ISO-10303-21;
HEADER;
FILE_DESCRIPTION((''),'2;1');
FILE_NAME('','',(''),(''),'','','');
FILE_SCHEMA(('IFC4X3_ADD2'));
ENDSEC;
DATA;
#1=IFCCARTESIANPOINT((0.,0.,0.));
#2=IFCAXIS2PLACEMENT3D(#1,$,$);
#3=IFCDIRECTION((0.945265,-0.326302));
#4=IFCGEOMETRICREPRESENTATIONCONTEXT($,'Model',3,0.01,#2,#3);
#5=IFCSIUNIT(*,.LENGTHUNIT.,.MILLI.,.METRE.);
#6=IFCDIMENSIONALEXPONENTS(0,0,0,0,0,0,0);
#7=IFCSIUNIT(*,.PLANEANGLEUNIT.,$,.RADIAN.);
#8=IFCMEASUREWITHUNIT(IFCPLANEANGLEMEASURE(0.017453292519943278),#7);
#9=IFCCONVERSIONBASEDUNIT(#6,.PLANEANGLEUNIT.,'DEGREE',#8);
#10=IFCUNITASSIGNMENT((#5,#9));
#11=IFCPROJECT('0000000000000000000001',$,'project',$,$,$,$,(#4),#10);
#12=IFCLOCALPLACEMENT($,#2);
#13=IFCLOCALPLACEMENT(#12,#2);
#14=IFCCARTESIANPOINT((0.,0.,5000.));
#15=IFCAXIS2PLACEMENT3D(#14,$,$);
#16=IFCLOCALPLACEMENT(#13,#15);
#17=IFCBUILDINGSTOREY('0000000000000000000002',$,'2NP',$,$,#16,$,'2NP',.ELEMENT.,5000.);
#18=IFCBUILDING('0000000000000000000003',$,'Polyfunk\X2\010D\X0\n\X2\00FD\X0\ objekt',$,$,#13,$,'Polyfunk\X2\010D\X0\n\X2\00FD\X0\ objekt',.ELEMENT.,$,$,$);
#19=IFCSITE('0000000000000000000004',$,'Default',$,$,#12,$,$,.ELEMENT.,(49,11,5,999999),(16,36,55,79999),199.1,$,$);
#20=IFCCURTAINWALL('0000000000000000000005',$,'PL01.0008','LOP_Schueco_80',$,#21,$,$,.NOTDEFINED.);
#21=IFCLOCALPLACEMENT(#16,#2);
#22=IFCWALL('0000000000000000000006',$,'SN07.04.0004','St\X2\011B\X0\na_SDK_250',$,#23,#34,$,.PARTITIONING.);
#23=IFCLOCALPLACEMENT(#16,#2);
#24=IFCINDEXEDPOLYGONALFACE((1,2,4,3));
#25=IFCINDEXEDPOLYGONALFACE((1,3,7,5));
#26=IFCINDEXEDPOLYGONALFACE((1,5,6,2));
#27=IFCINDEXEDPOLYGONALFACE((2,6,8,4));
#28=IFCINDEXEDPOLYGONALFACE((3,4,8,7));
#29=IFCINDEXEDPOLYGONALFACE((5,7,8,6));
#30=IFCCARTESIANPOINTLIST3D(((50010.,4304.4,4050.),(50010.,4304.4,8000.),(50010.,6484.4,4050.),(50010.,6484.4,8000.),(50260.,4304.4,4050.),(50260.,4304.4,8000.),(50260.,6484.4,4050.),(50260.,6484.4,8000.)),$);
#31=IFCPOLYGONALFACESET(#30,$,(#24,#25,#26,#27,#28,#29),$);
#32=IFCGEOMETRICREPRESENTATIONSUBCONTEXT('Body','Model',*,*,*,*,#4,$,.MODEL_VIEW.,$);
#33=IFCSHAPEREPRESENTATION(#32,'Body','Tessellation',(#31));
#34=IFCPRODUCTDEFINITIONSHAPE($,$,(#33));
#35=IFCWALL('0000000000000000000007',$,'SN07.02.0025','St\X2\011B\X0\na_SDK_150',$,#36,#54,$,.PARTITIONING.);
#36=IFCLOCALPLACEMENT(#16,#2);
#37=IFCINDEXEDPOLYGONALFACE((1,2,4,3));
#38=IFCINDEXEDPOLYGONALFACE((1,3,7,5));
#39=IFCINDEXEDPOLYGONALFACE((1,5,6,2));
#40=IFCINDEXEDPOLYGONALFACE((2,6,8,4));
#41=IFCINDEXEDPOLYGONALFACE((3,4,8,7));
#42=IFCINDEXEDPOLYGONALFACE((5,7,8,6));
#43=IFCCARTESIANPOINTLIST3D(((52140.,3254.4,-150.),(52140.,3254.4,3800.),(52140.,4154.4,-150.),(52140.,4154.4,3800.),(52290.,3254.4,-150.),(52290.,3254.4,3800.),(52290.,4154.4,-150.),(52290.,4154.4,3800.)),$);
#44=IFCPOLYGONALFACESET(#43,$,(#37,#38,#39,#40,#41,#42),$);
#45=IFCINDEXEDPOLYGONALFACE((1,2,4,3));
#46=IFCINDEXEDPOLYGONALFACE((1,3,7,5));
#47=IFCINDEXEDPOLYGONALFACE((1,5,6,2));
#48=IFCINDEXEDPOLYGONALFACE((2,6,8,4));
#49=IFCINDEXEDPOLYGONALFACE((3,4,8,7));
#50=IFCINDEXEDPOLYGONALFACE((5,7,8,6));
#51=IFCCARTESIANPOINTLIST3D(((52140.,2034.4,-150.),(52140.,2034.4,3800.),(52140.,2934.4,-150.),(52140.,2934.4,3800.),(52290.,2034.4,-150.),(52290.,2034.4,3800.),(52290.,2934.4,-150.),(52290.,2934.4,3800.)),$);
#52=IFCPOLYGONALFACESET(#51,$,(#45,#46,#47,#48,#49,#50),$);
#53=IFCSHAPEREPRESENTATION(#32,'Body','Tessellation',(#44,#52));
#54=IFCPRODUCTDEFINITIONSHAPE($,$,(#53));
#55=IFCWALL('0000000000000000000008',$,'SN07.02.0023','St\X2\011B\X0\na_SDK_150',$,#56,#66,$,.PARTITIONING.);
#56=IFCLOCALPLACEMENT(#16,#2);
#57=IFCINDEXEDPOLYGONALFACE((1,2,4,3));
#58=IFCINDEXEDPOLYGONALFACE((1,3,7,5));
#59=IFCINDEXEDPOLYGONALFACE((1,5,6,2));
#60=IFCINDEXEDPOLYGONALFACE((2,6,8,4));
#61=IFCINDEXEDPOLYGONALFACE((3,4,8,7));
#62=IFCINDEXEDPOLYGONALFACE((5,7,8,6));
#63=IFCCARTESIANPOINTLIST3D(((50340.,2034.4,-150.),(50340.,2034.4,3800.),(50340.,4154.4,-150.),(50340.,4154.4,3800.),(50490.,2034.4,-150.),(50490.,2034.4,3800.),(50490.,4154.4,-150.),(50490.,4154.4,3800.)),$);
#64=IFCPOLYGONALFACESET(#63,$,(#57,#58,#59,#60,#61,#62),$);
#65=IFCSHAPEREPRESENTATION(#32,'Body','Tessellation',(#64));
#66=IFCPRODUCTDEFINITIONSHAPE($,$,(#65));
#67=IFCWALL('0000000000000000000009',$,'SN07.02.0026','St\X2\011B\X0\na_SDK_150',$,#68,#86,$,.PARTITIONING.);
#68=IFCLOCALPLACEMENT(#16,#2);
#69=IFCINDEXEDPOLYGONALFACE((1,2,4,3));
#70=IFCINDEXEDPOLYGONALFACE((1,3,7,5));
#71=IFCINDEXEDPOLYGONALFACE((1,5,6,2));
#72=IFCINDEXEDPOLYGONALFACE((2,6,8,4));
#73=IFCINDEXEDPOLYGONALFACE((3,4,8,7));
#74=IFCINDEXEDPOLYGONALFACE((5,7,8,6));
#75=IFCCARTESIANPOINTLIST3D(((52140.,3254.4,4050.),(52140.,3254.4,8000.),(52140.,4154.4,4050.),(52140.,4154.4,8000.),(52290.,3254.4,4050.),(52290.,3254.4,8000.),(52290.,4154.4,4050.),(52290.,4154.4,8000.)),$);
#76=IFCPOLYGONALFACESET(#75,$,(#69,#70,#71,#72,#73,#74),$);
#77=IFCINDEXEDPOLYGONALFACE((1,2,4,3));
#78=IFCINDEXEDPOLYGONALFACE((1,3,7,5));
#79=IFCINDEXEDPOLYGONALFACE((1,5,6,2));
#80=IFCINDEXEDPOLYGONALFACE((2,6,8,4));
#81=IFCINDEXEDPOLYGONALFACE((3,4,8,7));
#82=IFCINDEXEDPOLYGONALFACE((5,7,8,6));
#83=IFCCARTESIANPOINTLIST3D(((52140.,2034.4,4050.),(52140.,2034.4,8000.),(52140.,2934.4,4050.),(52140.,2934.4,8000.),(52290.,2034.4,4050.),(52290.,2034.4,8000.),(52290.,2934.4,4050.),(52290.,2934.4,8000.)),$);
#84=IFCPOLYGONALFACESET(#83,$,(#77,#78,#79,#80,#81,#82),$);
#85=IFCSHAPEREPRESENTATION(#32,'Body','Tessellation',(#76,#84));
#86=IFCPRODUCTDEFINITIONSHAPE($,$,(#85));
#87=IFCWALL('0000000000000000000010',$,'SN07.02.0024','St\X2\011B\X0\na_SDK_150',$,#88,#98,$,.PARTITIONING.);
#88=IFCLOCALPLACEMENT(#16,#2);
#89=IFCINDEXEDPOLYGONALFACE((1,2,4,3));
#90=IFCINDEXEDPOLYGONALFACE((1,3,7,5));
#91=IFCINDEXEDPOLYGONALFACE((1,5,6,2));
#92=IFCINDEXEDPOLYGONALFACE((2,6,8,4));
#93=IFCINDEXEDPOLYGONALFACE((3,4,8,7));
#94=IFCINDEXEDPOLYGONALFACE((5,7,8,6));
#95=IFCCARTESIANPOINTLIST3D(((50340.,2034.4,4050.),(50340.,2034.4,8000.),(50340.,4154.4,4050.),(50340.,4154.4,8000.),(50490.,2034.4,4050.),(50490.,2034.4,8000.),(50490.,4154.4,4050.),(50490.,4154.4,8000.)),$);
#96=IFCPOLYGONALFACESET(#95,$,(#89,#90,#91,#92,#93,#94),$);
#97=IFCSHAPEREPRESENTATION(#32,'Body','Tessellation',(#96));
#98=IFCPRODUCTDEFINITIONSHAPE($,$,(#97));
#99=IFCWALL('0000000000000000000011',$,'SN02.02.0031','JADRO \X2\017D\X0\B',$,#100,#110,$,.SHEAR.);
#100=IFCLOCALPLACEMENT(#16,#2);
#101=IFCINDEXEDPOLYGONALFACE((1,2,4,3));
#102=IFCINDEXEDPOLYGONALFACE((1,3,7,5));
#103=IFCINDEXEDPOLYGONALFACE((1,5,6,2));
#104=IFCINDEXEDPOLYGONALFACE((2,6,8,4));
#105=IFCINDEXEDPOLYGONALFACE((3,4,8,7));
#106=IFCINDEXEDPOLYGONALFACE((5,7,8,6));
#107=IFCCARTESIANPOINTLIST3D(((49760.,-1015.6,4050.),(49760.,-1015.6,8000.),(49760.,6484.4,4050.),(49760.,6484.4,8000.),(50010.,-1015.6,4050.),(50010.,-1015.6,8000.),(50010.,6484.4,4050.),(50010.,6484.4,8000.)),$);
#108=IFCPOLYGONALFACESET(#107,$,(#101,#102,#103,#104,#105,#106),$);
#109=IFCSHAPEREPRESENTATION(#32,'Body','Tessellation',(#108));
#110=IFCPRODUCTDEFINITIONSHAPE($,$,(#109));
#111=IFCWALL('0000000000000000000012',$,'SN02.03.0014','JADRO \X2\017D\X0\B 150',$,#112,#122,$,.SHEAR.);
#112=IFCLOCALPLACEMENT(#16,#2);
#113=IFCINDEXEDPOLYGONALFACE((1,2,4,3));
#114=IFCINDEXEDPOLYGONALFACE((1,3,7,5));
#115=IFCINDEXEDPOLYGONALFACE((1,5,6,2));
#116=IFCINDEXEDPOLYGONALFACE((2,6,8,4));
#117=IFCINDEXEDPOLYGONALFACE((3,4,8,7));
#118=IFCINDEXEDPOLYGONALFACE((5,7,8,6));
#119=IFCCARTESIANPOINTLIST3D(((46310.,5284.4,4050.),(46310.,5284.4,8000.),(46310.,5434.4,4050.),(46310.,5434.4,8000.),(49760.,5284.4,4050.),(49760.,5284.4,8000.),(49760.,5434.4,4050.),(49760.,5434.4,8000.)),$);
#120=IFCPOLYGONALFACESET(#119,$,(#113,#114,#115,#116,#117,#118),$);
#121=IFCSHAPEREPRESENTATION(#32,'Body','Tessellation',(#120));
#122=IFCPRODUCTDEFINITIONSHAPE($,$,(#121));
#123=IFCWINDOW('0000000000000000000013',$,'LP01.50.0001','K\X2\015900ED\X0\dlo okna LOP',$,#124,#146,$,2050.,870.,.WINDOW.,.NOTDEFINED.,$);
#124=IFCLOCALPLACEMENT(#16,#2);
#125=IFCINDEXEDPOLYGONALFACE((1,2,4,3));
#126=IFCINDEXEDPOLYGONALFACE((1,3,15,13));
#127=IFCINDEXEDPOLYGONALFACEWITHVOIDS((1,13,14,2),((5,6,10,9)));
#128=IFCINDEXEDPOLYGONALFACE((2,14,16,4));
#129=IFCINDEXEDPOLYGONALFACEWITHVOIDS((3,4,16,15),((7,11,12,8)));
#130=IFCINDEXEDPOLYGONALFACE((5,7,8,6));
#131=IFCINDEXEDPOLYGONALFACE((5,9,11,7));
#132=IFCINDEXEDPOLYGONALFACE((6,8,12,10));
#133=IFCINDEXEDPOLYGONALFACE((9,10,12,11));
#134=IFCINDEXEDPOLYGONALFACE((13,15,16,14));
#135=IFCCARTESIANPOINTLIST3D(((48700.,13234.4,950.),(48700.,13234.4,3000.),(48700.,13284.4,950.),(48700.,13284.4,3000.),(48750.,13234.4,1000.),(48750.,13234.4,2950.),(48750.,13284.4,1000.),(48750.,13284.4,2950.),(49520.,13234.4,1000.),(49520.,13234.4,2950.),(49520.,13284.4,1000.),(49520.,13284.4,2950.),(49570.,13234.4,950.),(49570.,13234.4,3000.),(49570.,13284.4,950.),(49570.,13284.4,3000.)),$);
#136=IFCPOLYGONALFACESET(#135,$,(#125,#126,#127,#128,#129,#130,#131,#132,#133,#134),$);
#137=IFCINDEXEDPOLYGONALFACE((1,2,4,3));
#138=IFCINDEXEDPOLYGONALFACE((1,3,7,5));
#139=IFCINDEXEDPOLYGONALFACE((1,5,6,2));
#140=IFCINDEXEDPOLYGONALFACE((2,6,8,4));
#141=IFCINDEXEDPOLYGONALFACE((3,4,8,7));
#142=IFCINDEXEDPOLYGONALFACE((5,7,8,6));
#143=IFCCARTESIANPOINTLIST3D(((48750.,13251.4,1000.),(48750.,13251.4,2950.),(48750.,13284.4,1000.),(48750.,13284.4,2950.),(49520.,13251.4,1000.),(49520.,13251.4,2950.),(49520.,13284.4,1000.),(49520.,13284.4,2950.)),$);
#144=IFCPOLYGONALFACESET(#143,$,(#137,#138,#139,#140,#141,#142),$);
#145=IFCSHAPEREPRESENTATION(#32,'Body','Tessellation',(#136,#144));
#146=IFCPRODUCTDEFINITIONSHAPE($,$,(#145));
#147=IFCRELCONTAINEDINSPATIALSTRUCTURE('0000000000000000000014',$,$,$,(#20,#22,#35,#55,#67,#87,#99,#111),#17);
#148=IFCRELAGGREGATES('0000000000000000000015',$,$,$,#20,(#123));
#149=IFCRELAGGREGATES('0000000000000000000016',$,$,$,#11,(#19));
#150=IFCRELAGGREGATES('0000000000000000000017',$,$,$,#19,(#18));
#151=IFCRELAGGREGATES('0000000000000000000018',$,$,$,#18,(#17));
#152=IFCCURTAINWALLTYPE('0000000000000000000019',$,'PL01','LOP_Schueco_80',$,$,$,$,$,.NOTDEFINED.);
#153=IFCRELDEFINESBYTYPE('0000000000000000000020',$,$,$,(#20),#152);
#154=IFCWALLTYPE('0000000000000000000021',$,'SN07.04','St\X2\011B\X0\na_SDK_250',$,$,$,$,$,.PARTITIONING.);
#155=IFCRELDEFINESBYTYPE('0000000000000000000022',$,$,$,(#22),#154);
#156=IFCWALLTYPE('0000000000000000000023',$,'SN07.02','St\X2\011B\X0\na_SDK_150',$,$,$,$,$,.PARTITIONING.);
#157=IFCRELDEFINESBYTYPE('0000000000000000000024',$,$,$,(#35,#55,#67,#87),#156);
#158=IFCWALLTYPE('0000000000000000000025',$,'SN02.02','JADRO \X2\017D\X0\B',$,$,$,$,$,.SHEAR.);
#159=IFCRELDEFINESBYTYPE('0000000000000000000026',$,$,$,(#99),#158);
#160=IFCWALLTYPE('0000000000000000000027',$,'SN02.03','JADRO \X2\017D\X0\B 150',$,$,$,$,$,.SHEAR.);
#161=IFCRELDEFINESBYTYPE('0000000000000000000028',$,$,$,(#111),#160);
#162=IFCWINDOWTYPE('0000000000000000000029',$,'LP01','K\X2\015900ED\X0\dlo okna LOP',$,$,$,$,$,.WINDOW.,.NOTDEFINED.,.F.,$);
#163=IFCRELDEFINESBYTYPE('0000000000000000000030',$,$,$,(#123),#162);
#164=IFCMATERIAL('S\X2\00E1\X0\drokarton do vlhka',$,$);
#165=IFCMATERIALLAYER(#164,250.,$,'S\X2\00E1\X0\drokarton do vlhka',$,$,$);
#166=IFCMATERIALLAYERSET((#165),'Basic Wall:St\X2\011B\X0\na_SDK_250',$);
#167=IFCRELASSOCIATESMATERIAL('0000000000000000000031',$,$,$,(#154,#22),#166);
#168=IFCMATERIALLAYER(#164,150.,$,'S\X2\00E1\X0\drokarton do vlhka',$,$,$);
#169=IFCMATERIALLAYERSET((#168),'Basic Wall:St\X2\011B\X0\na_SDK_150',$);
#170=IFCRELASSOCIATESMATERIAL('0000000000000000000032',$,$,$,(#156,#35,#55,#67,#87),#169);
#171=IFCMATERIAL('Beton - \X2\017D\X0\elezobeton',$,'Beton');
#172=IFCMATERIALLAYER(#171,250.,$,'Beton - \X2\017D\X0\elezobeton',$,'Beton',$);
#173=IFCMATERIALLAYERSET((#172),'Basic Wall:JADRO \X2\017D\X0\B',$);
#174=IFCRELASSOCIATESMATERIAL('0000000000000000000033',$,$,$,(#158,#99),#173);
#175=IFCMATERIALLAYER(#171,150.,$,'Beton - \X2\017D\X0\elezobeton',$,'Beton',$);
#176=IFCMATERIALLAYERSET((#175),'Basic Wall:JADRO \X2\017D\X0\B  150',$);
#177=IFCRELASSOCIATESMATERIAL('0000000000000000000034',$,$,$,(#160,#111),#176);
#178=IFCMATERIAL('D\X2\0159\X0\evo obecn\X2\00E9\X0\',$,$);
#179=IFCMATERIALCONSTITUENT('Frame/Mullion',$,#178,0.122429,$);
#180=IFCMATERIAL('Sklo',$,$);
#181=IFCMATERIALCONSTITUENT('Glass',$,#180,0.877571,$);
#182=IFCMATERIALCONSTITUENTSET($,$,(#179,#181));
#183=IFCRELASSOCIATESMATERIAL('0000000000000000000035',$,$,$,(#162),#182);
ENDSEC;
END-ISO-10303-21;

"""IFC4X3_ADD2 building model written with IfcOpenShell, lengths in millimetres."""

from ifc_helpers import new_model, entity, si_unit, converted_unit, direction, frame, frame_2d, origin, origin_2d_with_axis, place, context, subcontext, project, spatial, polyline, rectangle, outline, extrude, clip, bounded_halfspace, source, transform, mapped, material, layer, layer_set, constituent, constituent_set, type_object, type_shapes, element, aggregate, save


model = new_model("IFC4X3_ADD2")

# Units and contexts
model_context = context("Model", 3, precision=0.01, world=origin(), true_north=direction((0.945265, -0.326302)))
body_context = subcontext(model_context, "Body", "Model", "MODEL_VIEW")
ifc_project = project(units=[si_unit("LENGTHUNIT", "METRE", prefix="MILLI"), converted_unit("PLANEANGLEUNIT", "DEGREE", entity("IfcPlaneAngleMeasure", 0.017453292519943278), si_unit("PLANEANGLEUNIT", "RADIAN"), dimensions=[0, 0, 0, 0, 0, 0, 0])], contexts=[model_context])

# Site, building, storey
site_placement = place(None, origin())
site = spatial("IfcSite", under=ifc_project, at=site_placement, Name="Default", CompositionType="ELEMENT", RefLatitude=(49, 11, 5, 999999), RefLongitude=(16, 36, 55, 79999), RefElevation=199.1)
building_placement = place(site_placement, origin())
building = spatial("IfcBuilding", under=site, at=building_placement, Name="Polyfunkčný objekt", LongName="Polyfunkčný objekt", CompositionType="ELEMENT")
storey_placement = place(building_placement, frame((0.0, 0.0, 5000.0)))
storey = spatial("IfcBuildingStorey", under=building, at=storey_placement, Name="2NP", LongName="2NP", CompositionType="ELEMENT", Elevation=5000.0)

# Curtain wall
curtain_wall_type = type_object("IfcCurtainWallType", Name="PL01", Description="LOP_Schueco_80", PredefinedType="NOTDEFINED")
curtain_wall_placement = place(storey_placement, frame((0.0, 0.0, -5000.0)))
curtain_wall = element("IfcCurtainWall", 1, at=curtain_wall_placement, inside=storey, type_object=curtain_wall_type, Name="PL01.0008", Description="LOP_Schueco_80", PredefinedType="NOTDEFINED")
ifc_material_1 = material(Name="Sklo")

# Walls
ifc_material_2 = material(Name="Sádrokarton do vlhka")
ifc_layer_1 = layer(ifc_material_2, 250.0, Name="Sádrokarton do vlhka")
ifc_layer_set_1 = layer_set([ifc_layer_1], Name="Basic Wall:Stěna_SDK_250")
wall_type_1 = type_object("IfcWallType", Name="SN07.04", Description="Stěna_SDK_250", PredefinedType="PARTITIONING", material=ifc_layer_set_1)
wall_1_placement = place(storey_placement, frame((50135.0, 6484.4, 4050.0), z_axis=(0.0, 0.0, 1.0), x_axis=(0.0, -1.0, 0.0)))
element("IfcWall", 2, at=wall_1_placement, inside=storey, type_object=wall_type_1, material=ifc_layer_set_1, Name="SN07.04.0004", Description="Stěna_SDK_250", PredefinedType="PARTITIONING", context=body_context, shape_type="Clipping", body=[
    clip(clip(extrude(rectangle(XDim=2180.0, YDim=250.0, at=frame_2d((1090.0, 0.0), x_axis=(-1.0, 0.0))), origin(), (0.0, 0.0, 1.0), 3950.0), bounded_halfspace(frame((2180.0, -125.0, 0.0), z_axis=(0.0, 0.0, 1.0), x_axis=(0.0, -1.0, 0.0)), True, frame((2180.0, -125.0, 0.0)), polyline([(0.0, 0.0), (0.0, 250.0), (-1930.0, 250.0), (-2180.0, 250.0), (-2180.0, 0.0), (0.0, 0.0)]))), bounded_halfspace(frame((0.0, -125.0, 3950.0), z_axis=(0.0, 0.0, -1.0), x_axis=(0.0, 1.0, 0.0)), True, frame((0.0, -125.0, 3950.0)), polyline([(0.0, 0.0), (2180.0, 0.0), (2180.0, 250.0), (250.0, 250.0), (0.0, 250.0), (0.0, 0.0)]))),
])
ifc_layer_2 = layer(ifc_material_2, 150.0, Name="Sádrokarton do vlhka")
ifc_layer_set_2 = layer_set([ifc_layer_2], Name="Basic Wall:Stěna_SDK_150")
wall_type_2 = type_object("IfcWallType", Name="SN07.02", Description="Stěna_SDK_150", PredefinedType="PARTITIONING", material=ifc_layer_set_2)
wall_2_placement = place(storey_placement, frame((52215.0, 4154.4, -150.0), z_axis=(0.0, 0.0, 1.0), x_axis=(0.0, -1.0, 0.0)))
element("IfcWall", 3, at=wall_2_placement, inside=storey, type_object=wall_type_2, material=ifc_layer_set_2, Name="SN07.02.0025", Description="Stěna_SDK_150", PredefinedType="PARTITIONING", context=body_context, shape_type="SweptSolid", body=[
    extrude(rectangle(XDim=900.0, YDim=150.0, at=frame_2d((0.0, 0.0), x_axis=(1.0, 0.0))), frame((450.0, 0.0, 0.0)), (0.0, 0.0, 1.0), 3950.0),
    extrude(rectangle(XDim=900.0, YDim=150.0, at=frame_2d((0.0, 0.0), x_axis=(1.0, 0.0))), frame((1670.0, 0.0, 0.0), z_axis=(0.0, 0.0, 1.0), x_axis=(-1.0, 0.0, 0.0)), (0.0, 0.0, 1.0), 3950.0),
])
wall_3_placement = place(storey_placement, frame((50415.0, 4154.4, -150.0), z_axis=(0.0, 0.0, 1.0), x_axis=(0.0, -1.0, 0.0)))
element("IfcWall", 4, at=wall_3_placement, inside=storey, type_object=wall_type_2, material=ifc_layer_set_2, Name="SN07.02.0023", Description="Stěna_SDK_150", PredefinedType="PARTITIONING", context=body_context, shape_type="Clipping", body=[
    clip(clip(extrude(rectangle(XDim=2120.0, YDim=150.0, at=frame_2d((1060.0, 0.0), x_axis=(-1.0, 0.0))), origin(), (0.0, 0.0, 1.0), 3950.0), bounded_halfspace(frame((2120.0, -75.0, 0.0), z_axis=(0.0, 0.0, 1.0), x_axis=(0.0, -1.0, 0.0)), True, frame((2120.0, -75.0, 0.0)), polyline([(0.0, 0.0), (0.0, 150.0), (-900.0, 150.0), (-1220.0, 150.0), (-2120.0, 150.0), (-2120.0, 0.0), (0.0, 0.0)]))), bounded_halfspace(frame((0.0, -75.0, 3950.0), z_axis=(0.0, 0.0, -1.0), x_axis=(0.0, 1.0, 0.0)), True, frame((0.0, -75.0, 3950.0)), polyline([(0.0, 0.0), (2120.0, 0.0), (2120.0, 150.0), (1220.0, 150.0), (900.0, 150.0), (0.0, 150.0), (0.0, 0.0)]))),
])
wall_4_placement = place(storey_placement, frame((52215.0, 4154.4, 4050.0), z_axis=(0.0, 0.0, 1.0), x_axis=(0.0, -1.0, 0.0)))
element("IfcWall", 5, at=wall_4_placement, inside=storey, type_object=wall_type_2, material=ifc_layer_set_2, Name="SN07.02.0026", Description="Stěna_SDK_150", PredefinedType="PARTITIONING", context=body_context, shape_type="SweptSolid", body=[
    extrude(rectangle(XDim=900.0, YDim=150.0, at=frame_2d((0.0, 0.0), x_axis=(1.0, 0.0))), frame((450.0, 0.0, 0.0)), (0.0, 0.0, 1.0), 3950.0),
    extrude(rectangle(XDim=900.0, YDim=150.0, at=frame_2d((0.0, 0.0), x_axis=(1.0, 0.0))), frame((1670.0, 0.0, 0.0), z_axis=(0.0, 0.0, 1.0), x_axis=(-1.0, 0.0, 0.0)), (0.0, 0.0, 1.0), 3950.0),
])
wall_5_placement = place(storey_placement, frame((50415.0, 4154.4, 4050.0), z_axis=(0.0, 0.0, 1.0), x_axis=(0.0, -1.0, 0.0)))
element("IfcWall", 6, at=wall_5_placement, inside=storey, type_object=wall_type_2, material=ifc_layer_set_2, Name="SN07.02.0024", Description="Stěna_SDK_150", PredefinedType="PARTITIONING", context=body_context, shape_type="Clipping", body=[
    clip(clip(extrude(rectangle(XDim=2120.0, YDim=150.0, at=frame_2d((1060.0, 0.0), x_axis=(-1.0, 0.0))), origin(), (0.0, 0.0, 1.0), 3950.0), bounded_halfspace(frame((2120.0, -75.0, 0.0), z_axis=(0.0, 0.0, 1.0), x_axis=(0.0, -1.0, 0.0)), True, frame((2120.0, -75.0, 0.0)), polyline([(0.0, 0.0), (0.0, 150.0), (-900.0, 150.0), (-1220.0, 150.0), (-2120.0, 150.0), (-2120.0, 0.0), (0.0, 0.0)]))), bounded_halfspace(frame((0.0, -75.0, 3950.0), z_axis=(0.0, 0.0, -1.0), x_axis=(0.0, 1.0, 0.0)), True, frame((0.0, -75.0, 3950.0)), polyline([(0.0, 0.0), (2120.0, 0.0), (2120.0, 150.0), (1220.0, 150.0), (900.0, 150.0), (0.0, 150.0), (0.0, 0.0)]))),
])
ifc_material_3 = material(Name="Beton - Železobeton", Category="Beton")
ifc_layer_3 = layer(ifc_material_3, 250.0, Name="Beton - Železobeton", Category="Beton")
ifc_layer_set_3 = layer_set([ifc_layer_3], Name="Basic Wall:JADRO ŽB")
wall_type_3 = type_object("IfcWallType", Name="SN02.02", Description="JADRO ŽB", PredefinedType="SHEAR", material=ifc_layer_set_3)
wall_6_placement = place(storey_placement, frame((49885.0, 6484.4, 4050.0), z_axis=(0.0, 0.0, 1.0), x_axis=(0.0, -1.0, 0.0)))
element("IfcWall", 7, at=wall_6_placement, inside=storey, type_object=wall_type_3, material=ifc_layer_set_3, Name="SN02.02.0031", Description="JADRO ŽB", PredefinedType="SHEAR", context=body_context, shape_type="Clipping", body=[
    clip(clip(extrude(rectangle(XDim=7500.0, YDim=250.0, at=frame_2d((3750.0, 0.0), x_axis=(-1.0, 0.0))), origin(), (0.0, 0.0, 1.0), 3950.0), bounded_halfspace(frame((7500.0, -125.0, 0.0), z_axis=(0.0, 0.0, 1.0), x_axis=(0.0, -1.0, 0.0)), True, frame((7500.0, -125.0, 0.0)), polyline([(0.0, 0.0), (0.0, 250.0), (-7500.0, 250.0), (-7500.0, 0.0), (-7250.0, 0.0), (-6450.0, 0.0), (-6300.0, 0.0), (0.0, 0.0)]))), bounded_halfspace(frame((0.0, -125.0, 3950.0), z_axis=(0.0, 0.0, -1.0), x_axis=(0.0, 1.0, 0.0)), True, frame((0.0, -125.0, 3950.0)), polyline([(0.0, 0.0), (250.0, 0.0), (1050.0, 0.0), (1200.0, 0.0), (7500.0, 0.0), (7500.0, 250.0), (0.0, 250.0), (0.0, 0.0)]))),
])
ifc_layer_4 = layer(ifc_material_3, 150.0, Name="Beton - Železobeton", Category="Beton")
ifc_layer_set_4 = layer_set([ifc_layer_4], Name="Basic Wall:JADRO ŽB  150")
wall_type_4 = type_object("IfcWallType", Name="SN02.03", Description="JADRO ŽB 150", PredefinedType="SHEAR", material=ifc_layer_set_4)
wall_7_placement = place(storey_placement, frame((46310.0, 5359.4, 4050.0)))
element("IfcWall", 8, at=wall_7_placement, inside=storey, type_object=wall_type_4, material=ifc_layer_set_4, Name="SN02.03.0014", Description="JADRO ŽB 150", PredefinedType="SHEAR", context=body_context, shape_type="SweptSolid", body=[
    extrude(rectangle(XDim=3450.0, YDim=150.0, at=frame_2d((1725.0, 0.0), x_axis=(-1.0, 0.0))), origin(), (0.0, 0.0, 1.0), 3950.0),
])

# Window
ifc_material_4 = material(Name="Dřevo obecné")
ifc_constituent_1 = constituent(ifc_material_4, Name="Frame/Mullion", fraction=0.122429)
ifc_constituent_2 = constituent(ifc_material_1, Name="Glass", fraction=0.877571)
ifc_constituent_set = constituent_set(constituents=[ifc_constituent_1, ifc_constituent_2])
window_type = type_object("IfcWindowType", Name="LP01", Description="Křídlo okna LOP", ParameterTakesPrecedence=False, PartitioningType="NOTDEFINED", PredefinedType="WINDOW", material=ifc_constituent_set)
shared_shape_1 = source(origin(), body_context, "Body", "SweptSolid", [
    extrude(outline(polyline([(-1025.0, -435.0), (1025.0, -435.0), (1025.0, 435.0), (-1025.0, 435.0), (-1025.0, -435.0)]), holes=[polyline([(-975.0, -385.0), (-975.0, 385.0), (975.0, 385.0), (975.0, -385.0), (-975.0, -385.0)])]), frame((0.0, 0.0, 1025.0), z_axis=(0.0, 1.0, 0.0), x_axis=(0.0, 0.0, -1.0)), (0.0, 0.0, 1.0), 50.0),
    extrude(rectangle(XDim=33.0, YDim=770.0, at=origin_2d_with_axis()), frame((0.0, 33.5, 50.0), z_axis=(0.0, 0.0, 1.0), x_axis=(0.0, -1.0, 0.0)), (0.0, 0.0, 1.0), 1950.0),
])
type_shapes(window_type, [shared_shape_1])
window_placement = place(curtain_wall_placement, frame((49135.0, 13234.4, 5950.0)))
window = element("IfcWindow", 9, at=window_placement, type_object=window_type, Name="LP01.50.0001", Description="Křídlo okna LOP", OverallHeight=2050.0, OverallWidth=870.0, PartitioningType="NOTDEFINED", PredefinedType="WINDOW", context=body_context, shape_type="MappedRepresentation", body=[
    mapped(shared_shape_1, transform((0.0, 0.0, 0.0), scale=1.0)),
])
aggregate(curtain_wall, [window])

save(model, "model.ifc")
